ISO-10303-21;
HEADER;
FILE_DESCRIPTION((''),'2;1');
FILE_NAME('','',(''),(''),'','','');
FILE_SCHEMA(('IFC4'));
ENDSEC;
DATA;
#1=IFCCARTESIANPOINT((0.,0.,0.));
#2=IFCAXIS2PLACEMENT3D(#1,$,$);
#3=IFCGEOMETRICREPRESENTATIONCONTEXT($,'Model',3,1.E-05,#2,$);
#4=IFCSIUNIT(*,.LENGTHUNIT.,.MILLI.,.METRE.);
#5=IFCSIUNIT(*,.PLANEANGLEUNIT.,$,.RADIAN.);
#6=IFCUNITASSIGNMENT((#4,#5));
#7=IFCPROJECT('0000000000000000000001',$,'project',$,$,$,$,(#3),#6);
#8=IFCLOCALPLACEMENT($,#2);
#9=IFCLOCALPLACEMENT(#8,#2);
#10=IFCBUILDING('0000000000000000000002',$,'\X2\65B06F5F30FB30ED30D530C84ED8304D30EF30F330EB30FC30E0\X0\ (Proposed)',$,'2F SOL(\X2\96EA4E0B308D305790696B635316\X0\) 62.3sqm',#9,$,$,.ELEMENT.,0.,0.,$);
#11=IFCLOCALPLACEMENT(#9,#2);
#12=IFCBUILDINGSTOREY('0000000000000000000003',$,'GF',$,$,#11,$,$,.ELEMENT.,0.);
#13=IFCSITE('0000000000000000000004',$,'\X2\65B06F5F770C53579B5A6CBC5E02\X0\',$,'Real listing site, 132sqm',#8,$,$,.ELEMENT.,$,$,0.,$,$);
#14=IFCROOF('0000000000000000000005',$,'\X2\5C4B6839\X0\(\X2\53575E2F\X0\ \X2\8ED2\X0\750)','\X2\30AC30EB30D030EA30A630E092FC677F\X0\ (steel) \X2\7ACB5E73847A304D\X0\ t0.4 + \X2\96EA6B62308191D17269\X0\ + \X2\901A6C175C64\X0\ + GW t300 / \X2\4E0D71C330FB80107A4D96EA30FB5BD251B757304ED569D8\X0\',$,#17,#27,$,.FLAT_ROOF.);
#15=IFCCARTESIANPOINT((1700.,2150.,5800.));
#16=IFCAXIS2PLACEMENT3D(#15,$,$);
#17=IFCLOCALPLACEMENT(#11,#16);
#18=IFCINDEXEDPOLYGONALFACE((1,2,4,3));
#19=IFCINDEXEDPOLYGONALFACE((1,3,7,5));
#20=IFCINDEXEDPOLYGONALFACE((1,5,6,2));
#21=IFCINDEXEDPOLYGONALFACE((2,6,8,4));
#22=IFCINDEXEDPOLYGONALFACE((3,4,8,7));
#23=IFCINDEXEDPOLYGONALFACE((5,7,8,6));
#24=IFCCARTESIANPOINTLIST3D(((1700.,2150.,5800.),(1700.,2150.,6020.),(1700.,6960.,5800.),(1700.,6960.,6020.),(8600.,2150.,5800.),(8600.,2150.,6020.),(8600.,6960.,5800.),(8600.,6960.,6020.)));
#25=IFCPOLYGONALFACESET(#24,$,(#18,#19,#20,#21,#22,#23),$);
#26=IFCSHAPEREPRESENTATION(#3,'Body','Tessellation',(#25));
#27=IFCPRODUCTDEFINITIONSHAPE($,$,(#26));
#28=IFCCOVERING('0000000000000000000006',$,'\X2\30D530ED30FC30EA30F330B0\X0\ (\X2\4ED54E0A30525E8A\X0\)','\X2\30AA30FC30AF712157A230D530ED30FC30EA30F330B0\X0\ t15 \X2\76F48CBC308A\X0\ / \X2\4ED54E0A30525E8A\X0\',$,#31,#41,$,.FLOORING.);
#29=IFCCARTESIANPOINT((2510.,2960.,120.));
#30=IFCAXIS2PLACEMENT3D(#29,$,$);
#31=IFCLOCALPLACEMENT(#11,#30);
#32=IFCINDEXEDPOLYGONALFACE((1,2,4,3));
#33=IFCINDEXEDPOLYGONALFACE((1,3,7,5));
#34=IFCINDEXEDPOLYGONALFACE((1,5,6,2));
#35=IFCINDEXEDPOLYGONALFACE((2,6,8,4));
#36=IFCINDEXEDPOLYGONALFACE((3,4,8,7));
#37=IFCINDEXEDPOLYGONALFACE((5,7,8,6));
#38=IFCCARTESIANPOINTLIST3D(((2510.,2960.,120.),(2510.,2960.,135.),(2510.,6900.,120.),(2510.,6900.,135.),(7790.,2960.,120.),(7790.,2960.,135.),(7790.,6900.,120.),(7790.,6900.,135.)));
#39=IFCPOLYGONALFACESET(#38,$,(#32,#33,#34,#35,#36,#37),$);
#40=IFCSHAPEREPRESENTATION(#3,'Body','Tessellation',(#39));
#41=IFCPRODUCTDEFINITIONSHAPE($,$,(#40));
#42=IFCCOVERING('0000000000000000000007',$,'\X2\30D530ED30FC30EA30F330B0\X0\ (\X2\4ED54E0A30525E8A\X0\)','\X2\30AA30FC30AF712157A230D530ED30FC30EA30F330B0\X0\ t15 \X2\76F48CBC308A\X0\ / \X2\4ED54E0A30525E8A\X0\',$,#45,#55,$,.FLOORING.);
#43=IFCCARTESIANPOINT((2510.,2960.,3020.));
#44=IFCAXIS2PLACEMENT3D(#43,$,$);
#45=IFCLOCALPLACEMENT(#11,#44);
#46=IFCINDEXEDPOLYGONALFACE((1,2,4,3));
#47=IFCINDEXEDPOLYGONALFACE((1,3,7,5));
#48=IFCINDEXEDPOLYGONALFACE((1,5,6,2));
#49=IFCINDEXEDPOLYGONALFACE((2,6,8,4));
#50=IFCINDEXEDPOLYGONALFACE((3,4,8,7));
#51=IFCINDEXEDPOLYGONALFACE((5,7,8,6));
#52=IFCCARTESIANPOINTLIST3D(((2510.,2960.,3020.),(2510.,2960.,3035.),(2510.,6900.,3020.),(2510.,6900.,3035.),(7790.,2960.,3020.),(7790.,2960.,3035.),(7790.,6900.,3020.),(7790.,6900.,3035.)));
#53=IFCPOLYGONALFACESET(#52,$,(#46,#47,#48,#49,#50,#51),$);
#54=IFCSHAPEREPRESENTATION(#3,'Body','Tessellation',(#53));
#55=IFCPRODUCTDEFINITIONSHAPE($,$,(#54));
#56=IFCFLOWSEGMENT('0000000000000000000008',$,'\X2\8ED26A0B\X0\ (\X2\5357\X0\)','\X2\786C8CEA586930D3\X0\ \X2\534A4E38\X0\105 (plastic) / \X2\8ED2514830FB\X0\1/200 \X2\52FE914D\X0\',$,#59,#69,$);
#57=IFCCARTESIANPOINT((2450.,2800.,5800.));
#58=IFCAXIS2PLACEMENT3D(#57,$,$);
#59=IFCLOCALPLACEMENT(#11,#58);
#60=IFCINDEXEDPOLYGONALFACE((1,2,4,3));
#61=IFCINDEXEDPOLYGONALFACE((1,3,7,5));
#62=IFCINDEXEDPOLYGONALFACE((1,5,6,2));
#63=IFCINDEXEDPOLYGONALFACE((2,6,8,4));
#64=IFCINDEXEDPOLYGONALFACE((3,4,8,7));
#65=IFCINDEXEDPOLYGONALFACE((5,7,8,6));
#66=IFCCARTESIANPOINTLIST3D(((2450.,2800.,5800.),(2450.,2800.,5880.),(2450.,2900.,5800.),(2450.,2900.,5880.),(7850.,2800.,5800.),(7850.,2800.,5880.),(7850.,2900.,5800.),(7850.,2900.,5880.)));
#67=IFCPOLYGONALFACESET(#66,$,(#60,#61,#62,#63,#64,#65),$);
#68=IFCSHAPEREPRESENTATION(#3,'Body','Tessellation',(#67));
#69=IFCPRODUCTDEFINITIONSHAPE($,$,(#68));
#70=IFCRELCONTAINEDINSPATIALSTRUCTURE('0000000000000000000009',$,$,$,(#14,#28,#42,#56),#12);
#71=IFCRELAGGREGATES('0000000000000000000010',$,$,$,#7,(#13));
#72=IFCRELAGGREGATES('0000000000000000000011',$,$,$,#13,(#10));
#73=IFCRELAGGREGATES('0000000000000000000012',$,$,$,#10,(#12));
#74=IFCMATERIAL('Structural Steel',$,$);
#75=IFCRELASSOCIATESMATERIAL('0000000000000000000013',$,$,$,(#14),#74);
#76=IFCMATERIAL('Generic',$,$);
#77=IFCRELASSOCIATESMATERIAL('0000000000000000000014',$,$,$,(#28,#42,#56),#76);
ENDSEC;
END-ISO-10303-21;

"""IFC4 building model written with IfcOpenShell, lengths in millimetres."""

from ifc_helpers import new_model, si_unit, frame, frame_2d, origin, place, context, project, spatial, rectangle, extrude, material, element, save


model = new_model("IFC4")

# Units and contexts
model_context = context("Model", 3, precision=1e-05, world=origin())
ifc_project = project(units=[si_unit("LENGTHUNIT", "METRE", prefix="MILLI"), si_unit("PLANEANGLEUNIT", "RADIAN")], contexts=[model_context])

# Site, building, storey
site_placement = place(None, origin())
site = spatial("IfcSite", under=ifc_project, at=site_placement, Name="新潟県南魚沼市", ObjectType="Real listing site, 132sqm", CompositionType="ELEMENT", RefElevation=0.0)
building_placement = place(site_placement, origin())
building = spatial("IfcBuilding", under=site, at=building_placement, Name="新潟・ロフト付きワンルーム (Proposed)", ObjectType="2F SOL(雪下ろし適正化) 62.3sqm", CompositionType="ELEMENT", ElevationOfRefHeight=0.0, ElevationOfTerrain=0.0)
storey_placement = place(building_placement, origin())
storey = spatial("IfcBuildingStorey", under=building, at=storey_placement, Name="GF", CompositionType="ELEMENT", Elevation=0.0)

# Roof
ifc_material_1 = material(Name="Structural Steel")
for number, where, name in (
    (1, (1700.0, 2150.0, 5800.0), "屋根(南帯 軒750)"),
):
    element("IfcRoof", number, at=place(storey_placement, frame(where)), inside=storey, material=ifc_material_1, Name=name, Description="ガルバリウム鋼板 (steel) 立平葺き t0.4 + 雪止め金物 + 通気層 + GW t300 / 不燃・耐積雪・寒冷地仕様", PredefinedType="FLAT_ROOF", context=model_context, shape_type="SweptSolid", body=[
        extrude(rectangle(XDim=6900.0, YDim=4810.0, at=frame_2d((3450.0, 2405.0))), frame((1700.0, 2150.0, 5800.0)), (0.0, 0.0, 1.0), 220.0),
    ])

# Coverings
ifc_material_2 = material(Name="Generic")
covering_1_placement = place(storey_placement, frame((2510.0, 2960.0, 120.0)))
element("IfcCovering", 2, at=covering_1_placement, inside=storey, material=ifc_material_2, Name="フローリング (仕上げ床)", Description="オーク無垢フローリング t15 直貼り / 仕上げ床", PredefinedType="FLOORING", context=model_context, shape_type="SweptSolid", body=[
    extrude(rectangle(XDim=5280.0, YDim=3940.0, at=frame_2d((2640.0, 1970.0))), frame((2510.0, 2960.0, 120.0)), (0.0, 0.0, 1.0), 15.0),
])
covering_2_placement = place(storey_placement, frame((2510.0, 2960.0, 3020.0)))
element("IfcCovering", 3, at=covering_2_placement, inside=storey, material=ifc_material_2, Name="フローリング (仕上げ床)", Description="オーク無垢フローリング t15 直貼り / 仕上げ床", PredefinedType="FLOORING", context=model_context, shape_type="SweptSolid", body=[
    extrude(rectangle(XDim=5280.0, YDim=3940.0, at=frame_2d((2640.0, 1970.0))), frame((2510.0, 2960.0, 3020.0)), (0.0, 0.0, 1.0), 15.0),
])

# Flow segment
flow_segment_placement = place(storey_placement, frame((2450.0, 2800.0, 5800.0)))
element("IfcFlowSegment", 4, at=flow_segment_placement, inside=storey, material=ifc_material_2, Name="軒樋 (南)", Description="硬質塩ビ 半丸105 (plastic) / 軒先・1/200 勾配", context=model_context, shape_type="SweptSolid", body=[
    extrude(rectangle(XDim=5400.0, YDim=100.0, at=frame_2d((2700.0, 50.0))), frame((2450.0, 2800.0, 5800.0)), (0.0, 0.0, 1.0), 80.0),
])

save(model, "model.ifc")
